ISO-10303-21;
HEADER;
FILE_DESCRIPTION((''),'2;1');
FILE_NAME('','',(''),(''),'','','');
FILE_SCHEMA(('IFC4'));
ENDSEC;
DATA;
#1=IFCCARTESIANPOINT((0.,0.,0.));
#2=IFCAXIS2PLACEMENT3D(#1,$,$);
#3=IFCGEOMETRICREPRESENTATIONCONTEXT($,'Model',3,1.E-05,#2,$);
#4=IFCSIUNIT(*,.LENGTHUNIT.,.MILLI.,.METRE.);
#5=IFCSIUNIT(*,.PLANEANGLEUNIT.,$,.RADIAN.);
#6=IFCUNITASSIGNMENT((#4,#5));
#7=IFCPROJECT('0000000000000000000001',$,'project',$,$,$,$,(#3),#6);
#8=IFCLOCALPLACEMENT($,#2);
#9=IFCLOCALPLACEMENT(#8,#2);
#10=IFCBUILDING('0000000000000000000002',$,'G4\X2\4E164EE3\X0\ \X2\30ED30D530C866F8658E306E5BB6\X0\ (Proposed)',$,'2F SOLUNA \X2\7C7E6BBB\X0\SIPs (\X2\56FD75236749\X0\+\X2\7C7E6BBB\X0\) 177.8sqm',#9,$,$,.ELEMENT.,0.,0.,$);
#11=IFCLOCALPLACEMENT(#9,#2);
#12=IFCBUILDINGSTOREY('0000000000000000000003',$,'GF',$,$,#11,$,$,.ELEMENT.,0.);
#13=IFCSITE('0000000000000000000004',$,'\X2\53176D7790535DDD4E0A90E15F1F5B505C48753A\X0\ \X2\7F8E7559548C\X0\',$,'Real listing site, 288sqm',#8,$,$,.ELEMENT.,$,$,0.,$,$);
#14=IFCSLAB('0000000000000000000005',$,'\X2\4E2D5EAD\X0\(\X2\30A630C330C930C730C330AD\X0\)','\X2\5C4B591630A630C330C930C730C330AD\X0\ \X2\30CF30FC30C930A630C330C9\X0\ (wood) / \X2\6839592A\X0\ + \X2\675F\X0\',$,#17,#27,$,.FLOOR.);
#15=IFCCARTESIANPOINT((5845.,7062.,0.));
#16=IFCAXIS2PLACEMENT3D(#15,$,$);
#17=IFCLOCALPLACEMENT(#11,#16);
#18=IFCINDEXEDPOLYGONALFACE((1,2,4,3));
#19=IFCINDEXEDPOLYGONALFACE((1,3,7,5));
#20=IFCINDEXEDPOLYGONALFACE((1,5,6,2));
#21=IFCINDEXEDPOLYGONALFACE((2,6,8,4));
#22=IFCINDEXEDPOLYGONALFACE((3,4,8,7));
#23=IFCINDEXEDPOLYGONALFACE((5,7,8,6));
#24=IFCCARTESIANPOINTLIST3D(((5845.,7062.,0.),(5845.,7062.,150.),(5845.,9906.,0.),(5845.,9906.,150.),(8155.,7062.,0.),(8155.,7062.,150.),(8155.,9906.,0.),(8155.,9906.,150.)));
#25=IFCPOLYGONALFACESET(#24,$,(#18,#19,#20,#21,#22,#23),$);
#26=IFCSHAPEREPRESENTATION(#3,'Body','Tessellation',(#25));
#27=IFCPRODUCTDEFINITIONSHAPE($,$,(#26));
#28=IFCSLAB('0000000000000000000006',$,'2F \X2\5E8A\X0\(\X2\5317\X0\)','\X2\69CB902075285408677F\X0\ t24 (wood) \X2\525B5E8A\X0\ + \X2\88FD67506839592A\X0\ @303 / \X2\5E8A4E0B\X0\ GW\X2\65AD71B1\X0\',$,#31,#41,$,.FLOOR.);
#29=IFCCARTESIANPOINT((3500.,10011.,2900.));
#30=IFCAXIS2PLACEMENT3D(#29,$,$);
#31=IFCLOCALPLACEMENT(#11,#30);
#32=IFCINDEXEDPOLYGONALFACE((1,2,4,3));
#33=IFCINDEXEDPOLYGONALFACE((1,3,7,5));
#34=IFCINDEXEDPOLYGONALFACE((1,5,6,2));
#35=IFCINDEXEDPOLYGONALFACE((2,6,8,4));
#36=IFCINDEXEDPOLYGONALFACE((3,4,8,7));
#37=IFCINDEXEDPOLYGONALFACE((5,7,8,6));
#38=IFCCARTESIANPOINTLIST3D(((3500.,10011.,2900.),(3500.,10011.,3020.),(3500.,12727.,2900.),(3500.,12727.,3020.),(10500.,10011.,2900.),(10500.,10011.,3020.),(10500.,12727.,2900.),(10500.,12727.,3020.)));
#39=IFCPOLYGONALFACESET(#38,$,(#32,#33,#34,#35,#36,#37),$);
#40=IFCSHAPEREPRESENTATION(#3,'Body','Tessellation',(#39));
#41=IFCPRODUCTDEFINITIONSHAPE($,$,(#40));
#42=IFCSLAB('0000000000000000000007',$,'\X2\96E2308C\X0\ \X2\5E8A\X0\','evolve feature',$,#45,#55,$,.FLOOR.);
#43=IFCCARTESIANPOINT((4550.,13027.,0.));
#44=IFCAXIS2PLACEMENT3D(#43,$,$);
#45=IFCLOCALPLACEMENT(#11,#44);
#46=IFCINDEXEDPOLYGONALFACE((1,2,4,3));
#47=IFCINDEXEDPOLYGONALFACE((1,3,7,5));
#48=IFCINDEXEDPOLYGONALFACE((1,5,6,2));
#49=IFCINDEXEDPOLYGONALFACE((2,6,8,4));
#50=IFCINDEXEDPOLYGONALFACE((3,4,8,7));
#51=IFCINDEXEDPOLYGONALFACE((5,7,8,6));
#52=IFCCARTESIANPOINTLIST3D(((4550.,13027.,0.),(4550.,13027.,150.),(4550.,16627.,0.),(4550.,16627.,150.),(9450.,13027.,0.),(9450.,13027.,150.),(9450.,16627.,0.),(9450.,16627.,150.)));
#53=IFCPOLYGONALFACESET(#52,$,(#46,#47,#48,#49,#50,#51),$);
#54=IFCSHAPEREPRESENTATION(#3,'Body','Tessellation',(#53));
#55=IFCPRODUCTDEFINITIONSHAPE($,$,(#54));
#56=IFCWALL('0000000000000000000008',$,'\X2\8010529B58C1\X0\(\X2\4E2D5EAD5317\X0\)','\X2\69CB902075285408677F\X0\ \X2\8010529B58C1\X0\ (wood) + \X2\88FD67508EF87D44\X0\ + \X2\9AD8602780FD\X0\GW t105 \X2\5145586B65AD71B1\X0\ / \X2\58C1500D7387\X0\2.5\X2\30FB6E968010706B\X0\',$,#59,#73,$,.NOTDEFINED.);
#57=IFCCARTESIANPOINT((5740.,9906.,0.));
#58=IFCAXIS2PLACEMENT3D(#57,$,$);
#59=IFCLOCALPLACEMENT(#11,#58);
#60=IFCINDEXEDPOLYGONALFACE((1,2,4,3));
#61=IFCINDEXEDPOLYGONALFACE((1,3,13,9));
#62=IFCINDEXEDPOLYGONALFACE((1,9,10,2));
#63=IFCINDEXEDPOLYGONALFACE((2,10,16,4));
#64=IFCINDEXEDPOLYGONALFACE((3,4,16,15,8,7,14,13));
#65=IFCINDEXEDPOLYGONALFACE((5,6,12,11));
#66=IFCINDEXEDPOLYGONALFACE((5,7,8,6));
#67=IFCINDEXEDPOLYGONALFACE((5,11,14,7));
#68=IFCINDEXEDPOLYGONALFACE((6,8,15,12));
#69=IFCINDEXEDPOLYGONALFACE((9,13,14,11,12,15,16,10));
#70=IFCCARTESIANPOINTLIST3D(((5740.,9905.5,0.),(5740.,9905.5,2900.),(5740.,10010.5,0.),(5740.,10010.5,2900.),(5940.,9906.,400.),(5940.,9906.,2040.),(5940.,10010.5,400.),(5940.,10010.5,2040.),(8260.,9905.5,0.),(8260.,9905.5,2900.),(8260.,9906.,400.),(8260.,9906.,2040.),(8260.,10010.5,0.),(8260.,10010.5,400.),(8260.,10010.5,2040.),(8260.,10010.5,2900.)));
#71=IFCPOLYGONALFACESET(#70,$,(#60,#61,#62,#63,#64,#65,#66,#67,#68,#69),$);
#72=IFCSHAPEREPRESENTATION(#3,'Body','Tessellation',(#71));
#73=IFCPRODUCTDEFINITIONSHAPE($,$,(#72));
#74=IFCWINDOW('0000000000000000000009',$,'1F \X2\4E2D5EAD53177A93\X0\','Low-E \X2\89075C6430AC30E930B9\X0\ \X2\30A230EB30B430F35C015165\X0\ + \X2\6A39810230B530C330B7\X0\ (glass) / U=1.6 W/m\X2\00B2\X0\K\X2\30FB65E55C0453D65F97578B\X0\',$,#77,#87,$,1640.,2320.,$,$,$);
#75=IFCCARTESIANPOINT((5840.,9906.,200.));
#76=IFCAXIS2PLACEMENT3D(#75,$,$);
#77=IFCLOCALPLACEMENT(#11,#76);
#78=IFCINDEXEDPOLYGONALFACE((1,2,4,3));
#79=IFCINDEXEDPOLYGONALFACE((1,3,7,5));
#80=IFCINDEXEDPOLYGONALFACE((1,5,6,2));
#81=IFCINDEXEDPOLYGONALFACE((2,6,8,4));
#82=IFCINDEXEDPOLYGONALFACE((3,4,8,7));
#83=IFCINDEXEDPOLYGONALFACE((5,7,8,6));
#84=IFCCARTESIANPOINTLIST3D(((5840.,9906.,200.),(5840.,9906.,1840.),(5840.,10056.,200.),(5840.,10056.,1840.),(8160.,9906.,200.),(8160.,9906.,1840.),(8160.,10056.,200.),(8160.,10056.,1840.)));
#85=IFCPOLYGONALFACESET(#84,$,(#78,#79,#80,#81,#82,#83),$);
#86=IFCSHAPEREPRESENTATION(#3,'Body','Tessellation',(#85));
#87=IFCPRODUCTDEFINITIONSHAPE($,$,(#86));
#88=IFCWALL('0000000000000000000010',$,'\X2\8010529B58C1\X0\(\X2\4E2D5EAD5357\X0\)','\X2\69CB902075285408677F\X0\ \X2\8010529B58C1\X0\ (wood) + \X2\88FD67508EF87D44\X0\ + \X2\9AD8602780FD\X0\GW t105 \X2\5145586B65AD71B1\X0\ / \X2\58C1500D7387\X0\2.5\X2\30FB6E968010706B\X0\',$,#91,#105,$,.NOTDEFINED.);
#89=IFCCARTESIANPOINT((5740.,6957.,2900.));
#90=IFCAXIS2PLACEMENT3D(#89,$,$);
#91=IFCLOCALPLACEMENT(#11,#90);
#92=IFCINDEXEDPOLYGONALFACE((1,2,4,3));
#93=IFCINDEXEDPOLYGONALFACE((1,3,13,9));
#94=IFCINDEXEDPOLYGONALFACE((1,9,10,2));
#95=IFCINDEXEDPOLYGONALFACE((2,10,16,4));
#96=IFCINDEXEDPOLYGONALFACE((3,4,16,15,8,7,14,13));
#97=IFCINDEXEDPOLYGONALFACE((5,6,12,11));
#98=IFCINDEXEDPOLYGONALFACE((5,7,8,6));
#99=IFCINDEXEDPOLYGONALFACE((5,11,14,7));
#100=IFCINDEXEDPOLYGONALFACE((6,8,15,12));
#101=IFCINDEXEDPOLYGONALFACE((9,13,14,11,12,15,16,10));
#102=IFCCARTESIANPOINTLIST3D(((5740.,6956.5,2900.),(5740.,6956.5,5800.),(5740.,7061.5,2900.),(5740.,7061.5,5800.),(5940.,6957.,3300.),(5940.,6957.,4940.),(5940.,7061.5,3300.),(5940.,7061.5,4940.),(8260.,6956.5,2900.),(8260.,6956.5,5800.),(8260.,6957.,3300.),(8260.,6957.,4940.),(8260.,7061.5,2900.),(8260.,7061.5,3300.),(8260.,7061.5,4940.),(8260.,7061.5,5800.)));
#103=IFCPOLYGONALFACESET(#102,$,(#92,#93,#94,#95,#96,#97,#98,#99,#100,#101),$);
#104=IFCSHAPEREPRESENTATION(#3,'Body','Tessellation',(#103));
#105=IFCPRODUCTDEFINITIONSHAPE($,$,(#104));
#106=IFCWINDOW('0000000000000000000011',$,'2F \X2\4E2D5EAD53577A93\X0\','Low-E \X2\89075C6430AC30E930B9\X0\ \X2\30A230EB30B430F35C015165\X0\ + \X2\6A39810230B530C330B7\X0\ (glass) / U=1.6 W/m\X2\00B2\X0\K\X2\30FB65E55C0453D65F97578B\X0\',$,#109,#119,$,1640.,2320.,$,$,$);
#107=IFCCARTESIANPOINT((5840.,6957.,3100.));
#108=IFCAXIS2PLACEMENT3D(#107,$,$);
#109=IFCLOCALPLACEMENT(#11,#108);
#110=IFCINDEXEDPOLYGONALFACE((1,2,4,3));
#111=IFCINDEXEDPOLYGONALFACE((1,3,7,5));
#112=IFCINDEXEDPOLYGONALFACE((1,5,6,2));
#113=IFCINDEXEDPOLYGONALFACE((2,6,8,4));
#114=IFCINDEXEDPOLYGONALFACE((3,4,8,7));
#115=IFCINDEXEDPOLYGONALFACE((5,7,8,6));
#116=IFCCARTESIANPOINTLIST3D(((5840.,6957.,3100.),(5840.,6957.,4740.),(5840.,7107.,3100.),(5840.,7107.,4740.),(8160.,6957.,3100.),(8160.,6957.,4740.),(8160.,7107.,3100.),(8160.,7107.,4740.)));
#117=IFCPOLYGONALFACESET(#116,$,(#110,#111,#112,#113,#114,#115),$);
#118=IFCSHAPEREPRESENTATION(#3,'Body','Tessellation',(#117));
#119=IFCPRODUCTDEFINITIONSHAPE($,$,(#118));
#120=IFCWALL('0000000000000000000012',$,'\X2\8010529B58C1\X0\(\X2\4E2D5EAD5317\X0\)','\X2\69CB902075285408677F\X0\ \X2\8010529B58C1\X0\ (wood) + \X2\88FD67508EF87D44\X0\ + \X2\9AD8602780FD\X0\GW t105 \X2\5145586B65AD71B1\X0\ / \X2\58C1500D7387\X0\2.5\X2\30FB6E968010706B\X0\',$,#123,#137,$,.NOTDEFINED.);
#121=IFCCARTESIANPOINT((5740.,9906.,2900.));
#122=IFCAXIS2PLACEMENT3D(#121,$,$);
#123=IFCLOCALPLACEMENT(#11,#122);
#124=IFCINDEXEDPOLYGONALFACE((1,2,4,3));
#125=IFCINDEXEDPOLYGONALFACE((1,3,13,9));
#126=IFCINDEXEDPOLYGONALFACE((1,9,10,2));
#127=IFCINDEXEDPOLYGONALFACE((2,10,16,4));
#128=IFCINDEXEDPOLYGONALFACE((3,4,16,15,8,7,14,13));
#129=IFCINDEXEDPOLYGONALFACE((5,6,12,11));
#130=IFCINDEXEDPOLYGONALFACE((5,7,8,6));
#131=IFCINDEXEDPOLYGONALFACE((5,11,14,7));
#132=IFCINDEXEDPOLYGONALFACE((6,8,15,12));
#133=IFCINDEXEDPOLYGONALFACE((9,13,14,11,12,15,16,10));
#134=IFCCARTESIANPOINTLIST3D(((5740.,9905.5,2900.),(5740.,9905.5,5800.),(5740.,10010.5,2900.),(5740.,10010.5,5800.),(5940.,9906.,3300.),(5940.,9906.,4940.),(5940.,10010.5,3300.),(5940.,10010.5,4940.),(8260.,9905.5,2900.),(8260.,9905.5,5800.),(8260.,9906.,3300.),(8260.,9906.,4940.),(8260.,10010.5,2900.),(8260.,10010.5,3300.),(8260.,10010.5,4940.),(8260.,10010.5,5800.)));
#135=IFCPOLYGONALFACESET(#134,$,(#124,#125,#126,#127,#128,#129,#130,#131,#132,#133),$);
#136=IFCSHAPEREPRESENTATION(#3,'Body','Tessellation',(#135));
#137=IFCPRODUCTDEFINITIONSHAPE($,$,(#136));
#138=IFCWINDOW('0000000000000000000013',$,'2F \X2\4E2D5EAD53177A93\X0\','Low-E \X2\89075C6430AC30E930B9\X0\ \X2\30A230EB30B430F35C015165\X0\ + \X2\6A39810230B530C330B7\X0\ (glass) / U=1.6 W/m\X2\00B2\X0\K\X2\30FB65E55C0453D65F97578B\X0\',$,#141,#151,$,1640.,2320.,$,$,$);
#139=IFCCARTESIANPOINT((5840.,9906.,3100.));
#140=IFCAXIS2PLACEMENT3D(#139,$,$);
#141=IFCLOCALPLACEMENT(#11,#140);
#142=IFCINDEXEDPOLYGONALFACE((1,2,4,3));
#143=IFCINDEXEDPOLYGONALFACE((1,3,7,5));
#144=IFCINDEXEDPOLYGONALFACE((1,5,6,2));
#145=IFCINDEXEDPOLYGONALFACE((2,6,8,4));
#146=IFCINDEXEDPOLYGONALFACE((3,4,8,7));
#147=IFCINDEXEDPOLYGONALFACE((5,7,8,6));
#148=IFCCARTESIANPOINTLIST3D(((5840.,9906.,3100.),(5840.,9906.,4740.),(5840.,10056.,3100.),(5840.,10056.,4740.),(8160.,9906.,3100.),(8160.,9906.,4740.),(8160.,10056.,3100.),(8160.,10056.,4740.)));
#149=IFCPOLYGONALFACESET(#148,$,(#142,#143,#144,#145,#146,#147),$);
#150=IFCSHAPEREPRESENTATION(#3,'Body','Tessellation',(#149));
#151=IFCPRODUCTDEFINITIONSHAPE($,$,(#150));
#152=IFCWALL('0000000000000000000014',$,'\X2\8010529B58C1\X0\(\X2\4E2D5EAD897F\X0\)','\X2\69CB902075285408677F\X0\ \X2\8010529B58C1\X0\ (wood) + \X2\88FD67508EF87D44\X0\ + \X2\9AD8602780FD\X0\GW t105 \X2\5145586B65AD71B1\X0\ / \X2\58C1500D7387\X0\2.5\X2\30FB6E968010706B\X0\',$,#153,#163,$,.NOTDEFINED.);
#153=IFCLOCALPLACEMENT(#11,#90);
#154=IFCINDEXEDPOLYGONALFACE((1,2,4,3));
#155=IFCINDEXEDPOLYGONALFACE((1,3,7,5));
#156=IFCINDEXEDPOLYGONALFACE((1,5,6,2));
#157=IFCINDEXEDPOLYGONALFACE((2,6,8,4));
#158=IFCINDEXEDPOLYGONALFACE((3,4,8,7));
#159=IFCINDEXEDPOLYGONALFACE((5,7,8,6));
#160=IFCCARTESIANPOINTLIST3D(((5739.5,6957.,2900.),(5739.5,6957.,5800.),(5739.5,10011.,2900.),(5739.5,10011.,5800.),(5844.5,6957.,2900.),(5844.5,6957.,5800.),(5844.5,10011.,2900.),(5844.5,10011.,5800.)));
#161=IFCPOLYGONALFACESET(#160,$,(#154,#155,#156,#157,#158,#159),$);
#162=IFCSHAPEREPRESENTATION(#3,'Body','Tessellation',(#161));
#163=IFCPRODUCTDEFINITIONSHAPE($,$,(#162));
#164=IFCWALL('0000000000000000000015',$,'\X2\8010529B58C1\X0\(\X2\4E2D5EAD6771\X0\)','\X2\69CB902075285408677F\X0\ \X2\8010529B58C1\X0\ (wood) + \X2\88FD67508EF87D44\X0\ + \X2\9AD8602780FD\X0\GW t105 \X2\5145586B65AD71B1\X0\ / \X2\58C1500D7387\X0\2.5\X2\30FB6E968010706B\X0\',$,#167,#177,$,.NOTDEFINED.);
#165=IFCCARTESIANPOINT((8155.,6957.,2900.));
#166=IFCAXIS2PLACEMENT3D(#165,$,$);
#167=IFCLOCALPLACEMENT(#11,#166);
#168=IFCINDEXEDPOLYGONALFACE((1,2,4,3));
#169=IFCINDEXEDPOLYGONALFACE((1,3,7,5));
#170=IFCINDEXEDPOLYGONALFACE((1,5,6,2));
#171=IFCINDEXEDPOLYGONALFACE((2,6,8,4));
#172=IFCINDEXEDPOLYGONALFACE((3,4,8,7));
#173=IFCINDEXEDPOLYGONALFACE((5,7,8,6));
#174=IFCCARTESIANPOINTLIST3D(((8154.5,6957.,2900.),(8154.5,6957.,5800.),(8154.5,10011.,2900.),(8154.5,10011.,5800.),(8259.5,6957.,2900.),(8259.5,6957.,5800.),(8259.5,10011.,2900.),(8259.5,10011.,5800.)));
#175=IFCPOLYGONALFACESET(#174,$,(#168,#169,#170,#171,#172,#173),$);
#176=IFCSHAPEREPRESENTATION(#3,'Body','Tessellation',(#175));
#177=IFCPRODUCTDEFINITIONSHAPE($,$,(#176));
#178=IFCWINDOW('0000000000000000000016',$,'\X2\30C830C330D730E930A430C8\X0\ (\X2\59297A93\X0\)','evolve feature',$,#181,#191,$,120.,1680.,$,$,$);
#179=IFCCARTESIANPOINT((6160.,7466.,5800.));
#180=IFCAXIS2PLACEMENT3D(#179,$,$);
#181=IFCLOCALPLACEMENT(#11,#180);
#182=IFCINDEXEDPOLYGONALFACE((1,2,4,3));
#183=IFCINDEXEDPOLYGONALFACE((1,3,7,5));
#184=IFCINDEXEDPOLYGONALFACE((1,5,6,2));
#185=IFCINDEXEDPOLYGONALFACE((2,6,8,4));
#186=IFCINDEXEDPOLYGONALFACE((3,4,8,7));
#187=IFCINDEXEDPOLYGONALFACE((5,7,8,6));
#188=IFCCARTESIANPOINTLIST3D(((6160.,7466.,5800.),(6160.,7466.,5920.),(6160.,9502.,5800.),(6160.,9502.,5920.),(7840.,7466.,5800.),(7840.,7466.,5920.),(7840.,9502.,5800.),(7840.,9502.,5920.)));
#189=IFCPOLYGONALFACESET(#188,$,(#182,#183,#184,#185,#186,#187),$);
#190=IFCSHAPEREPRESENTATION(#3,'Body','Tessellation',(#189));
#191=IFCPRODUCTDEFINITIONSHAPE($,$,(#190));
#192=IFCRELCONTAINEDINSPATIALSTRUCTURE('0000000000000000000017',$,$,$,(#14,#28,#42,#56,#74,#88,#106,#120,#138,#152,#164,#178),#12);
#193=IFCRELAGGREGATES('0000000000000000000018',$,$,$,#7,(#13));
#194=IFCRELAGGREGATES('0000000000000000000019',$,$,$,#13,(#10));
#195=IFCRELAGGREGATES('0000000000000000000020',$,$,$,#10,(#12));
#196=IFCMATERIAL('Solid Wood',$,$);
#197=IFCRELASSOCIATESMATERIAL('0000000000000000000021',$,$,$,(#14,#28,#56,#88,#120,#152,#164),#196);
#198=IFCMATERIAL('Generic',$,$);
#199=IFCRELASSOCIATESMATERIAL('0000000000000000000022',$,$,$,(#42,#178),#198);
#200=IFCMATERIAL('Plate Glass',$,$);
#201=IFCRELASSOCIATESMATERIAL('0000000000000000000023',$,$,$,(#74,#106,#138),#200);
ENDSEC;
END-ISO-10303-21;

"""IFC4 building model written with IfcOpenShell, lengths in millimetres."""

from ifc_helpers import new_model, si_unit, frame, frame_2d, origin, place, context, project, spatial, rectangle, extrude, material, element, fill, save


model = new_model("IFC4")

# Units and contexts
model_context = context("Model", 3, precision=1e-05, world=origin())
ifc_project = project(units=[si_unit("LENGTHUNIT", "METRE", prefix="MILLI"), si_unit("PLANEANGLEUNIT", "RADIAN")], contexts=[model_context])

# Site, building, storey
site_placement = place(None, origin())
site = spatial("IfcSite", under=ifc_project, at=site_placement, Name="北海道川上郡弟子屈町 美留和", ObjectType="Real listing site, 288sqm", CompositionType="ELEMENT", RefElevation=0.0)
building_placement = place(site_placement, origin())
building = spatial("IfcBuilding", under=site, at=building_placement, Name="G4世代 ロフト書斎の家 (Proposed)", ObjectType="2F SOLUNA 籾殻SIPs (国産杉+籾殻) 177.8sqm", CompositionType="ELEMENT", ElevationOfRefHeight=0.0, ElevationOfTerrain=0.0)
storey_placement = place(building_placement, origin())
storey = spatial("IfcBuildingStorey", under=building, at=storey_placement, Name="GF", CompositionType="ELEMENT", Elevation=0.0)

# Slabs
ifc_material_1 = material(Name="Solid Wood")
slab_1_placement = place(storey_placement, frame((5845.0, 7062.0, 0.0)))
element("IfcSlab", 1, at=slab_1_placement, inside=storey, material=ifc_material_1, Name="中庭(ウッドデッキ)", Description="屋外ウッドデッキ ハードウッド (wood) / 根太 + 束", PredefinedType="FLOOR", context=model_context, shape_type="SweptSolid", body=[
    extrude(rectangle(XDim=2310.0, YDim=2844.0, at=frame_2d((1155.0, 1422.0))), frame((5845.0, 7062.0, 0.0)), (0.0, 0.0, 1.0), 150.0),
])
slab_2_placement = place(storey_placement, frame((3500.0, 10011.0, 2900.0)))
element("IfcSlab", 2, at=slab_2_placement, inside=storey, material=ifc_material_1, Name="2F 床(北)", Description="構造用合板 t24 (wood) 剛床 + 製材根太 @303 / 床下 GW断熱", PredefinedType="FLOOR", context=model_context, shape_type="SweptSolid", body=[
    extrude(rectangle(XDim=7000.0, YDim=2716.0, at=frame_2d((3500.0, 1358.0))), frame((3500.0, 10011.0, 2900.0)), (0.0, 0.0, 1.0), 120.0),
])
ifc_material_2 = material(Name="Generic")
slab_3_placement = place(storey_placement, frame((4550.0, 13027.0, 0.0)))
element("IfcSlab", 3, at=slab_3_placement, inside=storey, material=ifc_material_2, Name="離れ 床", Description="evolve feature", PredefinedType="FLOOR", context=model_context, shape_type="SweptSolid", body=[
    extrude(rectangle(XDim=4900.0, YDim=3600.0, at=frame_2d((2450.0, 1800.0))), frame((4550.0, 13027.0, 0.0)), (0.0, 0.0, 1.0), 150.0),
])

# Wall, opening, window
wall_1_placement = place(storey_placement, frame((5740.0, 9906.0, 0.0)))
wall_1 = element("IfcWall", 4, at=wall_1_placement, inside=storey, material=ifc_material_1, Name="耐力壁(中庭北)", Description="構造用合板 耐力壁 (wood) + 製材軸組 + 高性能GW t105 充填断熱 / 壁倍率2.5・準耐火", PredefinedType="NOTDEFINED", context=model_context, shape_type="SweptSolid", body=[
    extrude(rectangle(XDim=2520.0, YDim=105.0, at=frame_2d((1260.0, 52.0))), frame((5740.0, 9906.0, 0.0)), (0.0, 0.0, 1.0), 2900.0),
])
opening_1_placement = place(storey_placement, frame((5840.0, 9906.0, 200.0)))
opening_1 = element("IfcOpeningElement", 5, at=opening_1_placement, cuts=wall_1, PredefinedType="NOTDEFINED", context=model_context, shape_type="SweptSolid", body=[
    extrude(rectangle(XDim=2320.0, YDim=150.0, at=frame_2d((1160.0, 75.0))), frame((5840.0, 9906.0, 200.0)), (0.0, 0.0, 1.0), 1640.0),
])
ifc_material_3 = material(Name="Plate Glass")
window_1_placement = place(storey_placement, frame((5840.0, 9906.0, 200.0)))
window_1 = element("IfcWindow", 6, at=window_1_placement, inside=storey, material=ifc_material_3, Name="1F 中庭北窓", Description="Low-E 複層ガラス アルゴン封入 + 樹脂サッシ (glass) / U=1.6 W/m²K・日射取得型", OverallHeight=1640.0, OverallWidth=2320.0, context=model_context, shape_type="SweptSolid", body=[
    extrude(rectangle(XDim=2320.0, YDim=150.0, at=frame_2d((1160.0, 75.0))), frame((5840.0, 9906.0, 200.0)), (0.0, 0.0, 1.0), 1640.0),
])
fill(opening_1, window_1)

# Walls, openings, windows
wall_2_placement = place(storey_placement, frame((5740.0, 6957.0, 2900.0)))
wall_2 = element("IfcWall", 7, at=wall_2_placement, inside=storey, material=ifc_material_1, Name="耐力壁(中庭南)", Description="構造用合板 耐力壁 (wood) + 製材軸組 + 高性能GW t105 充填断熱 / 壁倍率2.5・準耐火", PredefinedType="NOTDEFINED", context=model_context, shape_type="SweptSolid", body=[
    extrude(rectangle(XDim=2520.0, YDim=105.0, at=frame_2d((1260.0, 52.0))), frame((5740.0, 6957.0, 2900.0)), (0.0, 0.0, 1.0), 2900.0),
])
opening_2_placement = place(storey_placement, frame((5840.0, 6957.0, 3100.0)))
opening_2 = element("IfcOpeningElement", 8, at=opening_2_placement, cuts=wall_2, PredefinedType="NOTDEFINED", context=model_context, shape_type="SweptSolid", body=[
    extrude(rectangle(XDim=2320.0, YDim=150.0, at=frame_2d((1160.0, 75.0))), frame((5840.0, 6957.0, 3100.0)), (0.0, 0.0, 1.0), 1640.0),
])
window_2_placement = place(storey_placement, frame((5840.0, 6957.0, 3100.0)))
window_2 = element("IfcWindow", 9, at=window_2_placement, inside=storey, material=ifc_material_3, Name="2F 中庭南窓", Description="Low-E 複層ガラス アルゴン封入 + 樹脂サッシ (glass) / U=1.6 W/m²K・日射取得型", OverallHeight=1640.0, OverallWidth=2320.0, context=model_context, shape_type="SweptSolid", body=[
    extrude(rectangle(XDim=2320.0, YDim=150.0, at=frame_2d((1160.0, 75.0))), frame((5840.0, 6957.0, 3100.0)), (0.0, 0.0, 1.0), 1640.0),
])
fill(opening_2, window_2)
wall_3_placement = place(storey_placement, frame((5740.0, 9906.0, 2900.0)))
wall_3 = element("IfcWall", 10, at=wall_3_placement, inside=storey, material=ifc_material_1, Name="耐力壁(中庭北)", Description="構造用合板 耐力壁 (wood) + 製材軸組 + 高性能GW t105 充填断熱 / 壁倍率2.5・準耐火", PredefinedType="NOTDEFINED", context=model_context, shape_type="SweptSolid", body=[
    extrude(rectangle(XDim=2520.0, YDim=105.0, at=frame_2d((1260.0, 52.0))), frame((5740.0, 9906.0, 2900.0)), (0.0, 0.0, 1.0), 2900.0),
])
opening_3_placement = place(storey_placement, frame((5840.0, 9906.0, 3100.0)))
opening_3 = element("IfcOpeningElement", 11, at=opening_3_placement, cuts=wall_3, PredefinedType="NOTDEFINED", context=model_context, shape_type="SweptSolid", body=[
    extrude(rectangle(XDim=2320.0, YDim=150.0, at=frame_2d((1160.0, 75.0))), frame((5840.0, 9906.0, 3100.0)), (0.0, 0.0, 1.0), 1640.0),
])
window_3_placement = place(storey_placement, frame((5840.0, 9906.0, 3100.0)))
window_3 = element("IfcWindow", 12, at=window_3_placement, inside=storey, material=ifc_material_3, Name="2F 中庭北窓", Description="Low-E 複層ガラス アルゴン封入 + 樹脂サッシ (glass) / U=1.6 W/m²K・日射取得型", OverallHeight=1640.0, OverallWidth=2320.0, context=model_context, shape_type="SweptSolid", body=[
    extrude(rectangle(XDim=2320.0, YDim=150.0, at=frame_2d((1160.0, 75.0))), frame((5840.0, 9906.0, 3100.0)), (0.0, 0.0, 1.0), 1640.0),
])
fill(opening_3, window_3)

# Walls
wall_4_placement = place(storey_placement, frame((5740.0, 6957.0, 2900.0)))
element("IfcWall", 13, at=wall_4_placement, inside=storey, material=ifc_material_1, Name="耐力壁(中庭西)", Description="構造用合板 耐力壁 (wood) + 製材軸組 + 高性能GW t105 充填断熱 / 壁倍率2.5・準耐火", PredefinedType="NOTDEFINED", context=model_context, shape_type="SweptSolid", body=[
    extrude(rectangle(XDim=105.0, YDim=3054.0, at=frame_2d((52.0, 1527.0))), frame((5740.0, 6957.0, 2900.0)), (0.0, 0.0, 1.0), 2900.0),
])
wall_5_placement = place(storey_placement, frame((8155.0, 6957.0, 2900.0)))
element("IfcWall", 14, at=wall_5_placement, inside=storey, material=ifc_material_1, Name="耐力壁(中庭東)", Description="構造用合板 耐力壁 (wood) + 製材軸組 + 高性能GW t105 充填断熱 / 壁倍率2.5・準耐火", PredefinedType="NOTDEFINED", context=model_context, shape_type="SweptSolid", body=[
    extrude(rectangle(XDim=105.0, YDim=3054.0, at=frame_2d((52.0, 1527.0))), frame((8155.0, 6957.0, 2900.0)), (0.0, 0.0, 1.0), 2900.0),
])

# Window
window_4_placement = place(storey_placement, frame((6160.0, 7466.0, 5800.0)))
element("IfcWindow", 15, at=window_4_placement, inside=storey, material=ifc_material_2, Name="トップライト (天窓)", Description="evolve feature", OverallHeight=120.0, OverallWidth=1680.0, context=model_context, shape_type="SweptSolid", body=[
    extrude(rectangle(XDim=1680.0, YDim=2036.0, at=frame_2d((840.0, 1018.0))), frame((6160.0, 7466.0, 5800.0)), (0.0, 0.0, 1.0), 120.0),
])

save(model, "model.ifc")
